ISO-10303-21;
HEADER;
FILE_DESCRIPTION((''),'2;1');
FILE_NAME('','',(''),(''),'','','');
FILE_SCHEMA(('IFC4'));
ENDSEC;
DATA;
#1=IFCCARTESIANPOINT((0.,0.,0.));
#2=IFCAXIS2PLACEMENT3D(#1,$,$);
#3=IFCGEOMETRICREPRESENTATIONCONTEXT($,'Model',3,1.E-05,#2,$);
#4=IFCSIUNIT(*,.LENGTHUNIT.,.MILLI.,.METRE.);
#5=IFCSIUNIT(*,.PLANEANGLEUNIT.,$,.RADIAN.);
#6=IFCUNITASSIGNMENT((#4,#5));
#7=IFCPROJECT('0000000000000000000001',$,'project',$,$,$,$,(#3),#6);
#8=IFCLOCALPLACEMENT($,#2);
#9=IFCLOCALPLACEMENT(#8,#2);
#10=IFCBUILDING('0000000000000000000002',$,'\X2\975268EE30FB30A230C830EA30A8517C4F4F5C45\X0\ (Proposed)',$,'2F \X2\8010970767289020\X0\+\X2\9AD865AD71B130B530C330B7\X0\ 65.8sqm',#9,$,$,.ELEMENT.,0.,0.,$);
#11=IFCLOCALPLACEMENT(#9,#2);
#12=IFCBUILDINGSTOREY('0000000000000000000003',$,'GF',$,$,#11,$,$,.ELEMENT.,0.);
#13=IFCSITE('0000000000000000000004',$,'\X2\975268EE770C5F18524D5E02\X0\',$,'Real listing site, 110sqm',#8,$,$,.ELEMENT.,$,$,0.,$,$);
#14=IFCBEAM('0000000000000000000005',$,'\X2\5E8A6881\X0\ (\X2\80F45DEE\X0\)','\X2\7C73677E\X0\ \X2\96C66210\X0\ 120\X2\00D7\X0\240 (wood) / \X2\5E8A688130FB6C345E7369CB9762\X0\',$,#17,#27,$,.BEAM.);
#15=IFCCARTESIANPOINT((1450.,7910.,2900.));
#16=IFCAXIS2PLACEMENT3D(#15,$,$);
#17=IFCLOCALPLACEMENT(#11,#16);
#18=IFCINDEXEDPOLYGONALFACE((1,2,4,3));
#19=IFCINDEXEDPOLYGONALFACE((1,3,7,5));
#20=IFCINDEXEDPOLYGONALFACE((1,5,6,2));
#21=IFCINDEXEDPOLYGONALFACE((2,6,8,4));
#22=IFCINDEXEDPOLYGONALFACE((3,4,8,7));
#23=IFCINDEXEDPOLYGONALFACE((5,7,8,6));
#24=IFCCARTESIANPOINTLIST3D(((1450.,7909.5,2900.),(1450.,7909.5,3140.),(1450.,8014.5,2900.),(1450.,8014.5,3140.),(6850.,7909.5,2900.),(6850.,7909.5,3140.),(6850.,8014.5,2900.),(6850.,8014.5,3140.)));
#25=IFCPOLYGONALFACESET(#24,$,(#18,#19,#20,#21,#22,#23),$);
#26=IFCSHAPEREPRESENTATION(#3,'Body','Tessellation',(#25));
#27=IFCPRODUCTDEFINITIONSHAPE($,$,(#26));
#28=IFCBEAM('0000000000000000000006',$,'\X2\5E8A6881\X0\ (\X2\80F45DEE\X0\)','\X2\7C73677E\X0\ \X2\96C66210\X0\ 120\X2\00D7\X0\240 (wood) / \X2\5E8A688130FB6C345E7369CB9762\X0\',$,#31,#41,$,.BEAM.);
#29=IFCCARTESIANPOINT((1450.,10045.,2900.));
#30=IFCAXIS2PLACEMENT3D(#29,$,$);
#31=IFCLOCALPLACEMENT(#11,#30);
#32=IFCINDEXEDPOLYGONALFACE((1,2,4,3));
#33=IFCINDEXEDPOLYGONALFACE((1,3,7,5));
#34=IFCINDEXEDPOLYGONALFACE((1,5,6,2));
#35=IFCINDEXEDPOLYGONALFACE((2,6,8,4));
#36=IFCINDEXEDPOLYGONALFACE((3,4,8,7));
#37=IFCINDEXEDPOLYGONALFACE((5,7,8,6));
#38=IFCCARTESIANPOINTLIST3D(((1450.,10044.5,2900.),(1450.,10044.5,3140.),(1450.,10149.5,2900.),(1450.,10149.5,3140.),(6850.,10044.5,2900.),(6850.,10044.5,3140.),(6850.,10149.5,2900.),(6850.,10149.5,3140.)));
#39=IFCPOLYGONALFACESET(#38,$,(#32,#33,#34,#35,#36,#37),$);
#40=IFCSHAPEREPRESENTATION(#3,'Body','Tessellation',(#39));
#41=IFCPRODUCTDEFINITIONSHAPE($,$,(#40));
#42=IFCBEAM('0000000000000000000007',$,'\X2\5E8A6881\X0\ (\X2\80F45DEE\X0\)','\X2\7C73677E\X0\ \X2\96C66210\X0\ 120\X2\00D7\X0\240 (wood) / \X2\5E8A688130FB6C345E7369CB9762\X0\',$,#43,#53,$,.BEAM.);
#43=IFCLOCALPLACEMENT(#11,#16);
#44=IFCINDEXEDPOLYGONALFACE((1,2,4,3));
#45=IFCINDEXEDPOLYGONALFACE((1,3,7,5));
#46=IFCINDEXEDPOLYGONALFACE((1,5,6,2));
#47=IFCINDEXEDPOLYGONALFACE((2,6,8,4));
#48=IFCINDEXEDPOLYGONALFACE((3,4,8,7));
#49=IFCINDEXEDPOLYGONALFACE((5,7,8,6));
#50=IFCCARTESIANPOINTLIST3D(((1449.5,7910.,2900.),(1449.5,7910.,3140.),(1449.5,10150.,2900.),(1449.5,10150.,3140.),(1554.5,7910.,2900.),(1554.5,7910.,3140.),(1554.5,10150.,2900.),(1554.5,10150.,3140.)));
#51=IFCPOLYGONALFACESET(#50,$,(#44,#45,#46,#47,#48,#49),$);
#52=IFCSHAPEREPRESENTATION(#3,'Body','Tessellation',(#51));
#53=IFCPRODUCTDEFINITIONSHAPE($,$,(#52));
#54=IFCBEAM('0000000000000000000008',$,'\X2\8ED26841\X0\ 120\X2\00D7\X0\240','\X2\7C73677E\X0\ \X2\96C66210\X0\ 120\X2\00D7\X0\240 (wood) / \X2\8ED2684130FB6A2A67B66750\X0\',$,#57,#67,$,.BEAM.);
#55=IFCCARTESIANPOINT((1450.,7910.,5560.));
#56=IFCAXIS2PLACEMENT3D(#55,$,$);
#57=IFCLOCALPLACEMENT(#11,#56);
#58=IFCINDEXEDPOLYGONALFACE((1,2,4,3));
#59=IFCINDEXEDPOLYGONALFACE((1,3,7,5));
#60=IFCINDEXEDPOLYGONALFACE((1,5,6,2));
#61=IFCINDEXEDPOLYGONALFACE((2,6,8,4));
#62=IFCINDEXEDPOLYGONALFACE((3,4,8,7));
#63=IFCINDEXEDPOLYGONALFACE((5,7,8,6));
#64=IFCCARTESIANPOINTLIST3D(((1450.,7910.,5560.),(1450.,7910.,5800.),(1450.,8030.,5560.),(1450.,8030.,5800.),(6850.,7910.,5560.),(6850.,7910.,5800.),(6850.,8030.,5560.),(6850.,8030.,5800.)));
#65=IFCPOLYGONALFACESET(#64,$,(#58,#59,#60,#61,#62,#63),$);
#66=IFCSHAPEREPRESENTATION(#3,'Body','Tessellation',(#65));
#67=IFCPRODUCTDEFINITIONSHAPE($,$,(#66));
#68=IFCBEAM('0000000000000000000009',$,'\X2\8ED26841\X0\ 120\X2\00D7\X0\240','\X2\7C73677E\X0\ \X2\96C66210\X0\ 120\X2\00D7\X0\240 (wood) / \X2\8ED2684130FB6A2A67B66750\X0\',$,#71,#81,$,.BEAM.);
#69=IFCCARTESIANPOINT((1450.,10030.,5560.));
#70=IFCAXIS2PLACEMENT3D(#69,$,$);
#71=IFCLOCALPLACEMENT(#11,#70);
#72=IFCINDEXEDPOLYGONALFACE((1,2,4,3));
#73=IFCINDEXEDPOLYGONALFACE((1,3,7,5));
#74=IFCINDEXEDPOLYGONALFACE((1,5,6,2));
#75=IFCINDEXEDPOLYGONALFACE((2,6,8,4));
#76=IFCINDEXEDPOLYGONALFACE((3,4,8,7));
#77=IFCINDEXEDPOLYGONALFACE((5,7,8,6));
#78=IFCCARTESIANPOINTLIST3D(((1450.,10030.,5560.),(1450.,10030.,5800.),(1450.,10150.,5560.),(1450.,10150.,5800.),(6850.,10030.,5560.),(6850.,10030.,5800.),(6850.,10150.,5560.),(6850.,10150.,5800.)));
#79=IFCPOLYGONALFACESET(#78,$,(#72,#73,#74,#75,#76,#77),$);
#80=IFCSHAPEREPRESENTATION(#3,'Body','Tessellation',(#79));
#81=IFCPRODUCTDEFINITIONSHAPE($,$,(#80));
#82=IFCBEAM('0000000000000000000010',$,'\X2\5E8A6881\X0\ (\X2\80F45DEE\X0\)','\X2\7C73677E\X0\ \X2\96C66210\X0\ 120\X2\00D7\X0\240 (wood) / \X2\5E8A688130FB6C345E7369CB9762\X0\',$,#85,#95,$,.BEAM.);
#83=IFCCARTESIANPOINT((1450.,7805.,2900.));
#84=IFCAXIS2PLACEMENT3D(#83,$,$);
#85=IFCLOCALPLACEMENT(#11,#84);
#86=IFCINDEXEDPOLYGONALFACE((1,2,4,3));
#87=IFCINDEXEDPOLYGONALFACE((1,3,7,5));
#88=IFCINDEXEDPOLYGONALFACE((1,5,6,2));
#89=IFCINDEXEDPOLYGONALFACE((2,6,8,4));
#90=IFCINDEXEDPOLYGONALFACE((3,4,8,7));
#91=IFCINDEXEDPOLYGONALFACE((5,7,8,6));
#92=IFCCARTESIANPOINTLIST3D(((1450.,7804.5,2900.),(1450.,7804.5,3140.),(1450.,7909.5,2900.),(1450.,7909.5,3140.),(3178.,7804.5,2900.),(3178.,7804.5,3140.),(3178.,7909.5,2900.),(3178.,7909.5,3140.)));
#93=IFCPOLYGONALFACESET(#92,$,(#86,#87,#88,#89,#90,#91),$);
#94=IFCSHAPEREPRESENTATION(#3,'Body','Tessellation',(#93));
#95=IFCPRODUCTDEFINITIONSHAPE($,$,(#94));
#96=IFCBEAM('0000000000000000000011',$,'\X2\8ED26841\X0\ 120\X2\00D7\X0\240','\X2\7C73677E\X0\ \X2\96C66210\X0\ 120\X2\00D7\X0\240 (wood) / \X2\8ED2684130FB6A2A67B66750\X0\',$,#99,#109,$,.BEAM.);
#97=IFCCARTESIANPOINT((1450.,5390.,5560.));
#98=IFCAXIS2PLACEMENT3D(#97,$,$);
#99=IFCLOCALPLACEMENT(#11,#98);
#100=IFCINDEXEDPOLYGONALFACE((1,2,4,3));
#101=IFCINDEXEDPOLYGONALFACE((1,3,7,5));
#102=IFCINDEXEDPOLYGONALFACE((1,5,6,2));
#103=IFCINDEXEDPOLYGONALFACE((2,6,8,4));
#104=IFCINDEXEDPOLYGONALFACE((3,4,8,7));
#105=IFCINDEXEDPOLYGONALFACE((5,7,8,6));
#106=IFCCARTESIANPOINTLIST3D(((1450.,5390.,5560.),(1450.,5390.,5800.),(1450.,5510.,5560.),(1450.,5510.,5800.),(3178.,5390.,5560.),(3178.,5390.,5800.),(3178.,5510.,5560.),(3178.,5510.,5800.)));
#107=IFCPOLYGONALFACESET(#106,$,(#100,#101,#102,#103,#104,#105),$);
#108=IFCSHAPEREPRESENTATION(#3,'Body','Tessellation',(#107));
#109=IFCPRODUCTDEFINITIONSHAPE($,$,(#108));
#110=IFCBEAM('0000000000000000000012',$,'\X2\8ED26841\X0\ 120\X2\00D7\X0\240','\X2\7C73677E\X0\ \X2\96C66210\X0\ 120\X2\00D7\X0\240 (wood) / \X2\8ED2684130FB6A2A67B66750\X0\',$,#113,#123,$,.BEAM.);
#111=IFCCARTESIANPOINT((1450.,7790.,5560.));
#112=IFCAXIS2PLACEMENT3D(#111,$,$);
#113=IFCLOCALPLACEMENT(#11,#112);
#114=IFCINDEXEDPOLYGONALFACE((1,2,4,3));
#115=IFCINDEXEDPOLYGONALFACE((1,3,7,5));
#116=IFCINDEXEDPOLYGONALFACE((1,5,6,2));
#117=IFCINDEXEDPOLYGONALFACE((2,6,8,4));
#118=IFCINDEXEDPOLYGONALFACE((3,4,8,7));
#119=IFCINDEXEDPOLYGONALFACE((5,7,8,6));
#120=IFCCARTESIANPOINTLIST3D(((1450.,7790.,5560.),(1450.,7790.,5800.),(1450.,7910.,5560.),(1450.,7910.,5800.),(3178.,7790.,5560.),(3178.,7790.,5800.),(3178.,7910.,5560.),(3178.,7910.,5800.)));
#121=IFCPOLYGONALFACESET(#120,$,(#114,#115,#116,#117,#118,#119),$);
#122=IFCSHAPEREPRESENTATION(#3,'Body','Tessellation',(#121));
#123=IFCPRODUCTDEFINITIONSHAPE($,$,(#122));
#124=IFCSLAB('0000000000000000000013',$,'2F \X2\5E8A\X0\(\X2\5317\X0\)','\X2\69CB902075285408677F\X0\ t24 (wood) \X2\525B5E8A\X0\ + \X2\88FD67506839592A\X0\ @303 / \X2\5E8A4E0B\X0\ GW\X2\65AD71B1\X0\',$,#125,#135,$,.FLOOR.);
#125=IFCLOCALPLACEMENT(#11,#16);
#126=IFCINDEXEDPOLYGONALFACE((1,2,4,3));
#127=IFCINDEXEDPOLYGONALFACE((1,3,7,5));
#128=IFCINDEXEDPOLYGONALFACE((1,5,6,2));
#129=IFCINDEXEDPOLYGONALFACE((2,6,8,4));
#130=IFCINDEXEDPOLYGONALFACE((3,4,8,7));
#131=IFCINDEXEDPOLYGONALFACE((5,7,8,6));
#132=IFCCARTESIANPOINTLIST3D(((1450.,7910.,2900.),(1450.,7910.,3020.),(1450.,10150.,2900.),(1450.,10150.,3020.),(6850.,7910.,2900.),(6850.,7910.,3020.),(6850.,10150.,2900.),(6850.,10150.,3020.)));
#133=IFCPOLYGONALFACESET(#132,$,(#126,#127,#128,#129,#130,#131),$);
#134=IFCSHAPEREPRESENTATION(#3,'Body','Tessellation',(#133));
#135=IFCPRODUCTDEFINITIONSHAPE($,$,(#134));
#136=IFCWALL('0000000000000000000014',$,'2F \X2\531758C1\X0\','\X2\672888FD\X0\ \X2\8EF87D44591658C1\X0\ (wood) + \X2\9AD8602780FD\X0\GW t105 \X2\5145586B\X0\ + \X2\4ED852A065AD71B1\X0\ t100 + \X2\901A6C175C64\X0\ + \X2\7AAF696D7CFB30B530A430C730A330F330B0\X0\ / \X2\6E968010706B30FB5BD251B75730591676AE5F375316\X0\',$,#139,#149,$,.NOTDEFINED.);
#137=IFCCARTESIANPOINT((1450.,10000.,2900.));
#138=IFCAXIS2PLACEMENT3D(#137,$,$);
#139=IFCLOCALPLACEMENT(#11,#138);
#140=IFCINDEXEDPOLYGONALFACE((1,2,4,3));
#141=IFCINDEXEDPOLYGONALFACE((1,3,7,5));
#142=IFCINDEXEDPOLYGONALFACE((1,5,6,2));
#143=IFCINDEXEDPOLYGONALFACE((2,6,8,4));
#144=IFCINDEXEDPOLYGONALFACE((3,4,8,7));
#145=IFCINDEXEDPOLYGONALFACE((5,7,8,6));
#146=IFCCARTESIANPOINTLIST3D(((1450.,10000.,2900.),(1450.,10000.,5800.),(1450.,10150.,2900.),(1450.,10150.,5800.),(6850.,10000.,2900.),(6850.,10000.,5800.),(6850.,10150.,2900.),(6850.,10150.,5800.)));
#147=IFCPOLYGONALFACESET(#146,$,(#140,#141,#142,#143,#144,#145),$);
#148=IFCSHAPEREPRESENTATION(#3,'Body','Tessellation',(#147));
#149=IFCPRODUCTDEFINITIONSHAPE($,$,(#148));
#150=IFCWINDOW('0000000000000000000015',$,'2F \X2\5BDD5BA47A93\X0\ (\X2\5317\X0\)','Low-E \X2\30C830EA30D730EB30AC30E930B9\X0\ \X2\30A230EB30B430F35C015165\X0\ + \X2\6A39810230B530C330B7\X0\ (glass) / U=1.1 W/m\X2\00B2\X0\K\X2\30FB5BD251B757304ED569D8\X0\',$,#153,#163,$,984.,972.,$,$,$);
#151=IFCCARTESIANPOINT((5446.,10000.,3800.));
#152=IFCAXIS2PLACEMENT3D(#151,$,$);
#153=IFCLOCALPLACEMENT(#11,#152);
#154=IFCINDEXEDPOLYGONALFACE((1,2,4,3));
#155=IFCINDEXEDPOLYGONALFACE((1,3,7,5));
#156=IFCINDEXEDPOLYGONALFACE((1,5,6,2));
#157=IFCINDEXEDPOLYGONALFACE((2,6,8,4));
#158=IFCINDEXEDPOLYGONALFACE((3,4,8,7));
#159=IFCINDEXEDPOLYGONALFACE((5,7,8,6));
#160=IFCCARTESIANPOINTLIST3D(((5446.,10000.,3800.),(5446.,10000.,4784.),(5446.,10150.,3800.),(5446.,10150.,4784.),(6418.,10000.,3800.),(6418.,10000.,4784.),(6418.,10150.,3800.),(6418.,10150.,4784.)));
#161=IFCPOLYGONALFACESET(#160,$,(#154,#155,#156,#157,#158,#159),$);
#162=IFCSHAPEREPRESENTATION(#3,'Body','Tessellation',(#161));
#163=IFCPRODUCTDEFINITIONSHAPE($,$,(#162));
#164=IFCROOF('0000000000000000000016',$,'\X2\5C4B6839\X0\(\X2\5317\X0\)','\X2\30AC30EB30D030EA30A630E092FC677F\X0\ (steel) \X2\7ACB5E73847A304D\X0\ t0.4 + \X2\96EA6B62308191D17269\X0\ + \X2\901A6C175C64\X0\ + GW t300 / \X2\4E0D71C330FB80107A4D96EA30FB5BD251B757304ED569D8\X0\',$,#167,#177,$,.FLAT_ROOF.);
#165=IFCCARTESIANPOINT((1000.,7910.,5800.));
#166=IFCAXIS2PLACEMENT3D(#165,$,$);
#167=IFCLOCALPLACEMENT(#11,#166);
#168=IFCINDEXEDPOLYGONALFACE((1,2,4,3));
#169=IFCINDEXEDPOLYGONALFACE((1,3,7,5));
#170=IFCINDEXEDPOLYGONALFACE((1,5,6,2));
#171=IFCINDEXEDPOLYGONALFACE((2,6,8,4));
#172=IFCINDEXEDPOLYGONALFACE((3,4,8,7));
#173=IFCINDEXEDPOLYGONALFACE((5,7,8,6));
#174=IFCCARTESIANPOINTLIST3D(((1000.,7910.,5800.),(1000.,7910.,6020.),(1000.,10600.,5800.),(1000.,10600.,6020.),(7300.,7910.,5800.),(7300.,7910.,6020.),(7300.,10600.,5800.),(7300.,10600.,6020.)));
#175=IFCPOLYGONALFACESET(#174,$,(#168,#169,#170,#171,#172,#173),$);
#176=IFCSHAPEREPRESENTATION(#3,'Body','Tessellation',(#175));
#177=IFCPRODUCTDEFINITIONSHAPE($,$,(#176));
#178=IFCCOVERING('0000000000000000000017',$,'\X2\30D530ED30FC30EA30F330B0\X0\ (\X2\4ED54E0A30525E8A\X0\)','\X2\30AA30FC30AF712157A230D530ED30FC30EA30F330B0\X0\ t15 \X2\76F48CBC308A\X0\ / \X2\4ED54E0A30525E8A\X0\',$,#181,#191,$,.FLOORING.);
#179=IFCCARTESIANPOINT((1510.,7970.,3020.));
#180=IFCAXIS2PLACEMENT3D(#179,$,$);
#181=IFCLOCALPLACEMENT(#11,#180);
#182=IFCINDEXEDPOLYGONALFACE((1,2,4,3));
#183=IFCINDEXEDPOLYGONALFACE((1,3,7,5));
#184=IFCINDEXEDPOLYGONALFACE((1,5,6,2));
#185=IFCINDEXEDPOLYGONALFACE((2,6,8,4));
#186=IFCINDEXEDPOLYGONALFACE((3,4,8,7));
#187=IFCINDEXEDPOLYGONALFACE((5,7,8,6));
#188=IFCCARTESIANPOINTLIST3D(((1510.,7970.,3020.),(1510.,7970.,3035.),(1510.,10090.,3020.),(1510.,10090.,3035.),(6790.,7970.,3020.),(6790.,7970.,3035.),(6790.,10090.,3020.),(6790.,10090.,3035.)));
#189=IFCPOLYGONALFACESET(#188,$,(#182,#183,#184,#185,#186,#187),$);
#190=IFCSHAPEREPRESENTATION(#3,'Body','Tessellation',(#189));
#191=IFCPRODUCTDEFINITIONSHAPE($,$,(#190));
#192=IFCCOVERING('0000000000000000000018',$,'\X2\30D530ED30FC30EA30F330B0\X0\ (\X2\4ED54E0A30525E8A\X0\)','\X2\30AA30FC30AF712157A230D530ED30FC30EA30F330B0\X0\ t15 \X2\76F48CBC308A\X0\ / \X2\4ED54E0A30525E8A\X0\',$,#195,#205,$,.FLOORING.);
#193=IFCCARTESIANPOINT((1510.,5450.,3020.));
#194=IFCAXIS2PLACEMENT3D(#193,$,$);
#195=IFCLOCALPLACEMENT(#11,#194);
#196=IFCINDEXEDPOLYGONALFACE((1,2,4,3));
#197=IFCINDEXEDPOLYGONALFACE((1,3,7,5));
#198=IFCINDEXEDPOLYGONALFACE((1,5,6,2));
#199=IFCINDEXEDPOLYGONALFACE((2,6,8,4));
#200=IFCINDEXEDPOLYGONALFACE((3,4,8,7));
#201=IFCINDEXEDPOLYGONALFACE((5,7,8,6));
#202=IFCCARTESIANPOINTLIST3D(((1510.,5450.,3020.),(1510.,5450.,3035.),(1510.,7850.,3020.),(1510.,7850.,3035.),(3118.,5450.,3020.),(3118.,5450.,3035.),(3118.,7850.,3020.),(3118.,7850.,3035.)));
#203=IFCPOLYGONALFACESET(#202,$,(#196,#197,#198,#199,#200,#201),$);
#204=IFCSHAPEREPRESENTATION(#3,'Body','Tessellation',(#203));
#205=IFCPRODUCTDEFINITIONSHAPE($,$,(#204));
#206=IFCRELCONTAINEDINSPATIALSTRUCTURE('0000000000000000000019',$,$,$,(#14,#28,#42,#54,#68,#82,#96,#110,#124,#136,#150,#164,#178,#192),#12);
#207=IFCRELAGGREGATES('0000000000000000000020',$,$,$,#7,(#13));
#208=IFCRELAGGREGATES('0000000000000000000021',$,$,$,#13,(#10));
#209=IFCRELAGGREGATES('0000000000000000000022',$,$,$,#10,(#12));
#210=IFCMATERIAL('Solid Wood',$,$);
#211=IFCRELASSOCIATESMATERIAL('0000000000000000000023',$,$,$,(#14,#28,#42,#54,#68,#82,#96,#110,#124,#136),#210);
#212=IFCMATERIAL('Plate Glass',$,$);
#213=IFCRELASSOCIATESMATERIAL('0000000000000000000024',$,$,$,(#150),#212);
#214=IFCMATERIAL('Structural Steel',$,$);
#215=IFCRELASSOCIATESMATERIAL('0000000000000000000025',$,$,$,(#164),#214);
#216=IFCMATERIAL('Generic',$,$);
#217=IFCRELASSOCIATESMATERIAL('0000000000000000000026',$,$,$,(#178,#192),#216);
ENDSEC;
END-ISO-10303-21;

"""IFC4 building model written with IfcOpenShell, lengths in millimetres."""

from ifc_helpers import new_model, si_unit, frame, frame_2d, origin, place, context, project, spatial, rectangle, extrude, material, element, fill, save


model = new_model("IFC4")

# Units and contexts
model_context = context("Model", 3, precision=1e-05, world=origin())
ifc_project = project(units=[si_unit("LENGTHUNIT", "METRE", prefix="MILLI"), si_unit("PLANEANGLEUNIT", "RADIAN")], contexts=[model_context])

# Site, building, storey
site_placement = place(None, origin())
site = spatial("IfcSite", under=ifc_project, at=site_placement, Name="青森県弘前市", ObjectType="Real listing site, 110sqm", CompositionType="ELEMENT", RefElevation=0.0)
building_placement = place(site_placement, origin())
building = spatial("IfcBuilding", under=site, at=building_placement, Name="青森・アトリエ兼住居 (Proposed)", ObjectType="2F 耐震木造+高断熱サッシ 65.8sqm", CompositionType="ELEMENT", ElevationOfRefHeight=0.0, ElevationOfTerrain=0.0)
storey_placement = place(building_placement, origin())
storey = spatial("IfcBuildingStorey", under=building, at=storey_placement, Name="GF", CompositionType="ELEMENT", Elevation=0.0)

# Shared definitions
ifc_material_1 = material(Name="Solid Wood")

# Beams
beam_1_placement = place(storey_placement, frame((1450.0, 7910.0, 2900.0)))
element("IfcBeam", 1, at=beam_1_placement, inside=storey, material=ifc_material_1, Name="床梁 (胴差)", Description="米松 集成 120×240 (wood) / 床梁・水平構面", PredefinedType="BEAM", context=model_context, shape_type="SweptSolid", body=[
    extrude(rectangle(XDim=5400.0, YDim=105.0, at=frame_2d((2700.0, 52.0))), frame((1450.0, 7910.0, 2900.0)), (0.0, 0.0, 1.0), 240.0),
])
beam_2_placement = place(storey_placement, frame((1450.0, 10045.0, 2900.0)))
element("IfcBeam", 2, at=beam_2_placement, inside=storey, material=ifc_material_1, Name="床梁 (胴差)", Description="米松 集成 120×240 (wood) / 床梁・水平構面", PredefinedType="BEAM", context=model_context, shape_type="SweptSolid", body=[
    extrude(rectangle(XDim=5400.0, YDim=105.0, at=frame_2d((2700.0, 52.0))), frame((1450.0, 10045.0, 2900.0)), (0.0, 0.0, 1.0), 240.0),
])
beam_3_placement = place(storey_placement, frame((1450.0, 7910.0, 2900.0)))
element("IfcBeam", 3, at=beam_3_placement, inside=storey, material=ifc_material_1, Name="床梁 (胴差)", Description="米松 集成 120×240 (wood) / 床梁・水平構面", PredefinedType="BEAM", context=model_context, shape_type="SweptSolid", body=[
    extrude(rectangle(XDim=105.0, YDim=2240.0, at=frame_2d((52.0, 1120.0))), frame((1450.0, 7910.0, 2900.0)), (0.0, 0.0, 1.0), 240.0),
])
beam_4_placement = place(storey_placement, frame((1450.0, 7910.0, 5560.0)))
element("IfcBeam", 4, at=beam_4_placement, inside=storey, material=ifc_material_1, Name="軒桁 120×240", Description="米松 集成 120×240 (wood) / 軒桁・横架材", PredefinedType="BEAM", context=model_context, shape_type="SweptSolid", body=[
    extrude(rectangle(XDim=5400.0, YDim=120.0, at=frame_2d((2700.0, 60.0))), frame((1450.0, 7910.0, 5560.0)), (0.0, 0.0, 1.0), 240.0),
])
beam_5_placement = place(storey_placement, frame((1450.0, 10030.0, 5560.0)))
element("IfcBeam", 5, at=beam_5_placement, inside=storey, material=ifc_material_1, Name="軒桁 120×240", Description="米松 集成 120×240 (wood) / 軒桁・横架材", PredefinedType="BEAM", context=model_context, shape_type="SweptSolid", body=[
    extrude(rectangle(XDim=5400.0, YDim=120.0, at=frame_2d((2700.0, 60.0))), frame((1450.0, 10030.0, 5560.0)), (0.0, 0.0, 1.0), 240.0),
])
beam_6_placement = place(storey_placement, frame((1450.0, 7805.0, 2900.0)))
element("IfcBeam", 6, at=beam_6_placement, inside=storey, material=ifc_material_1, Name="床梁 (胴差)", Description="米松 集成 120×240 (wood) / 床梁・水平構面", PredefinedType="BEAM", context=model_context, shape_type="SweptSolid", body=[
    extrude(rectangle(XDim=1728.0, YDim=105.0, at=frame_2d((864.0, 52.0))), frame((1450.0, 7805.0, 2900.0)), (0.0, 0.0, 1.0), 240.0),
])
beam_7_placement = place(storey_placement, frame((1450.0, 5390.0, 5560.0)))
element("IfcBeam", 7, at=beam_7_placement, inside=storey, material=ifc_material_1, Name="軒桁 120×240", Description="米松 集成 120×240 (wood) / 軒桁・横架材", PredefinedType="BEAM", context=model_context, shape_type="SweptSolid", body=[
    extrude(rectangle(XDim=1728.0, YDim=120.0, at=frame_2d((864.0, 60.0))), frame((1450.0, 5390.0, 5560.0)), (0.0, 0.0, 1.0), 240.0),
])
beam_8_placement = place(storey_placement, frame((1450.0, 7790.0, 5560.0)))
element("IfcBeam", 8, at=beam_8_placement, inside=storey, material=ifc_material_1, Name="軒桁 120×240", Description="米松 集成 120×240 (wood) / 軒桁・横架材", PredefinedType="BEAM", context=model_context, shape_type="SweptSolid", body=[
    extrude(rectangle(XDim=1728.0, YDim=120.0, at=frame_2d((864.0, 60.0))), frame((1450.0, 7790.0, 5560.0)), (0.0, 0.0, 1.0), 240.0),
])

# Slab
slab_placement = place(storey_placement, frame((1450.0, 7910.0, 2900.0)))
element("IfcSlab", 9, at=slab_placement, inside=storey, material=ifc_material_1, Name="2F 床(北)", Description="構造用合板 t24 (wood) 剛床 + 製材根太 @303 / 床下 GW断熱", PredefinedType="FLOOR", context=model_context, shape_type="SweptSolid", body=[
    extrude(rectangle(XDim=5400.0, YDim=2240.0, at=frame_2d((2700.0, 1120.0))), frame((1450.0, 7910.0, 2900.0)), (0.0, 0.0, 1.0), 120.0),
])

# Wall, opening, window
wall_placement = place(storey_placement, frame((1450.0, 10000.0, 2900.0)))
wall = element("IfcWall", 10, at=wall_placement, inside=storey, material=ifc_material_1, Name="2F 北壁", Description="木製 軸組外壁 (wood) + 高性能GW t105 充填 + 付加断熱 t100 + 通気層 + 窯業系サイディング / 準耐火・寒冷地外皮強化", PredefinedType="NOTDEFINED", context=model_context, shape_type="SweptSolid", body=[
    extrude(rectangle(XDim=5400.0, YDim=150.0, at=frame_2d((2700.0, 75.0))), frame((1450.0, 10000.0, 2900.0)), (0.0, 0.0, 1.0), 2900.0),
])
opening_placement = place(storey_placement, frame((5446.0, 10000.0, 3800.0)))
opening = element("IfcOpeningElement", 11, at=opening_placement, cuts=wall, PredefinedType="NOTDEFINED", context=model_context, shape_type="SweptSolid", body=[
    extrude(rectangle(XDim=972.0, YDim=150.0, at=frame_2d((486.0, 75.0))), frame((5446.0, 10000.0, 3800.0)), (0.0, 0.0, 1.0), 984.0),
])
ifc_material_2 = material(Name="Plate Glass")
window_placement = place(storey_placement, frame((5446.0, 10000.0, 3800.0)))
window = element("IfcWindow", 12, at=window_placement, inside=storey, material=ifc_material_2, Name="2F 寝室窓 (北)", Description="Low-E トリプルガラス アルゴン封入 + 樹脂サッシ (glass) / U=1.1 W/m²K・寒冷地仕様", OverallHeight=984.0, OverallWidth=972.0, context=model_context, shape_type="SweptSolid", body=[
    extrude(rectangle(XDim=972.0, YDim=150.0, at=frame_2d((486.0, 75.0))), frame((5446.0, 10000.0, 3800.0)), (0.0, 0.0, 1.0), 984.0),
])
fill(opening, window)

# Roof
ifc_material_3 = material(Name="Structural Steel")
for number, where, name in (
    (13, (1000.0, 7910.0, 5800.0), "屋根(北)"),
):
    element("IfcRoof", number, at=place(storey_placement, frame(where)), inside=storey, material=ifc_material_3, Name=name, Description="ガルバリウム鋼板 (steel) 立平葺き t0.4 + 雪止め金物 + 通気層 + GW t300 / 不燃・耐積雪・寒冷地仕様", PredefinedType="FLAT_ROOF", context=model_context, shape_type="SweptSolid", body=[
        extrude(rectangle(XDim=6300.0, YDim=2690.0, at=frame_2d((3150.0, 1345.0))), frame((1000.0, 7910.0, 5800.0)), (0.0, 0.0, 1.0), 220.0),
    ])

# Coverings
ifc_material_4 = material(Name="Generic")
covering_1_placement = place(storey_placement, frame((1510.0, 7970.0, 3020.0)))
element("IfcCovering", 14, at=covering_1_placement, inside=storey, material=ifc_material_4, Name="フローリング (仕上げ床)", Description="オーク無垢フローリング t15 直貼り / 仕上げ床", PredefinedType="FLOORING", context=model_context, shape_type="SweptSolid", body=[
    extrude(rectangle(XDim=5280.0, YDim=2120.0, at=frame_2d((2640.0, 1060.0))), frame((1510.0, 7970.0, 3020.0)), (0.0, 0.0, 1.0), 15.0),
])
covering_2_placement = place(storey_placement, frame((1510.0, 5450.0, 3020.0)))
element("IfcCovering", 15, at=covering_2_placement, inside=storey, material=ifc_material_4, Name="フローリング (仕上げ床)", Description="オーク無垢フローリング t15 直貼り / 仕上げ床", PredefinedType="FLOORING", context=model_context, shape_type="SweptSolid", body=[
    extrude(rectangle(XDim=1608.0, YDim=2400.0, at=frame_2d((804.0, 1200.0))), frame((1510.0, 5450.0, 3020.0)), (0.0, 0.0, 1.0), 15.0),
])

save(model, "model.ifc")
